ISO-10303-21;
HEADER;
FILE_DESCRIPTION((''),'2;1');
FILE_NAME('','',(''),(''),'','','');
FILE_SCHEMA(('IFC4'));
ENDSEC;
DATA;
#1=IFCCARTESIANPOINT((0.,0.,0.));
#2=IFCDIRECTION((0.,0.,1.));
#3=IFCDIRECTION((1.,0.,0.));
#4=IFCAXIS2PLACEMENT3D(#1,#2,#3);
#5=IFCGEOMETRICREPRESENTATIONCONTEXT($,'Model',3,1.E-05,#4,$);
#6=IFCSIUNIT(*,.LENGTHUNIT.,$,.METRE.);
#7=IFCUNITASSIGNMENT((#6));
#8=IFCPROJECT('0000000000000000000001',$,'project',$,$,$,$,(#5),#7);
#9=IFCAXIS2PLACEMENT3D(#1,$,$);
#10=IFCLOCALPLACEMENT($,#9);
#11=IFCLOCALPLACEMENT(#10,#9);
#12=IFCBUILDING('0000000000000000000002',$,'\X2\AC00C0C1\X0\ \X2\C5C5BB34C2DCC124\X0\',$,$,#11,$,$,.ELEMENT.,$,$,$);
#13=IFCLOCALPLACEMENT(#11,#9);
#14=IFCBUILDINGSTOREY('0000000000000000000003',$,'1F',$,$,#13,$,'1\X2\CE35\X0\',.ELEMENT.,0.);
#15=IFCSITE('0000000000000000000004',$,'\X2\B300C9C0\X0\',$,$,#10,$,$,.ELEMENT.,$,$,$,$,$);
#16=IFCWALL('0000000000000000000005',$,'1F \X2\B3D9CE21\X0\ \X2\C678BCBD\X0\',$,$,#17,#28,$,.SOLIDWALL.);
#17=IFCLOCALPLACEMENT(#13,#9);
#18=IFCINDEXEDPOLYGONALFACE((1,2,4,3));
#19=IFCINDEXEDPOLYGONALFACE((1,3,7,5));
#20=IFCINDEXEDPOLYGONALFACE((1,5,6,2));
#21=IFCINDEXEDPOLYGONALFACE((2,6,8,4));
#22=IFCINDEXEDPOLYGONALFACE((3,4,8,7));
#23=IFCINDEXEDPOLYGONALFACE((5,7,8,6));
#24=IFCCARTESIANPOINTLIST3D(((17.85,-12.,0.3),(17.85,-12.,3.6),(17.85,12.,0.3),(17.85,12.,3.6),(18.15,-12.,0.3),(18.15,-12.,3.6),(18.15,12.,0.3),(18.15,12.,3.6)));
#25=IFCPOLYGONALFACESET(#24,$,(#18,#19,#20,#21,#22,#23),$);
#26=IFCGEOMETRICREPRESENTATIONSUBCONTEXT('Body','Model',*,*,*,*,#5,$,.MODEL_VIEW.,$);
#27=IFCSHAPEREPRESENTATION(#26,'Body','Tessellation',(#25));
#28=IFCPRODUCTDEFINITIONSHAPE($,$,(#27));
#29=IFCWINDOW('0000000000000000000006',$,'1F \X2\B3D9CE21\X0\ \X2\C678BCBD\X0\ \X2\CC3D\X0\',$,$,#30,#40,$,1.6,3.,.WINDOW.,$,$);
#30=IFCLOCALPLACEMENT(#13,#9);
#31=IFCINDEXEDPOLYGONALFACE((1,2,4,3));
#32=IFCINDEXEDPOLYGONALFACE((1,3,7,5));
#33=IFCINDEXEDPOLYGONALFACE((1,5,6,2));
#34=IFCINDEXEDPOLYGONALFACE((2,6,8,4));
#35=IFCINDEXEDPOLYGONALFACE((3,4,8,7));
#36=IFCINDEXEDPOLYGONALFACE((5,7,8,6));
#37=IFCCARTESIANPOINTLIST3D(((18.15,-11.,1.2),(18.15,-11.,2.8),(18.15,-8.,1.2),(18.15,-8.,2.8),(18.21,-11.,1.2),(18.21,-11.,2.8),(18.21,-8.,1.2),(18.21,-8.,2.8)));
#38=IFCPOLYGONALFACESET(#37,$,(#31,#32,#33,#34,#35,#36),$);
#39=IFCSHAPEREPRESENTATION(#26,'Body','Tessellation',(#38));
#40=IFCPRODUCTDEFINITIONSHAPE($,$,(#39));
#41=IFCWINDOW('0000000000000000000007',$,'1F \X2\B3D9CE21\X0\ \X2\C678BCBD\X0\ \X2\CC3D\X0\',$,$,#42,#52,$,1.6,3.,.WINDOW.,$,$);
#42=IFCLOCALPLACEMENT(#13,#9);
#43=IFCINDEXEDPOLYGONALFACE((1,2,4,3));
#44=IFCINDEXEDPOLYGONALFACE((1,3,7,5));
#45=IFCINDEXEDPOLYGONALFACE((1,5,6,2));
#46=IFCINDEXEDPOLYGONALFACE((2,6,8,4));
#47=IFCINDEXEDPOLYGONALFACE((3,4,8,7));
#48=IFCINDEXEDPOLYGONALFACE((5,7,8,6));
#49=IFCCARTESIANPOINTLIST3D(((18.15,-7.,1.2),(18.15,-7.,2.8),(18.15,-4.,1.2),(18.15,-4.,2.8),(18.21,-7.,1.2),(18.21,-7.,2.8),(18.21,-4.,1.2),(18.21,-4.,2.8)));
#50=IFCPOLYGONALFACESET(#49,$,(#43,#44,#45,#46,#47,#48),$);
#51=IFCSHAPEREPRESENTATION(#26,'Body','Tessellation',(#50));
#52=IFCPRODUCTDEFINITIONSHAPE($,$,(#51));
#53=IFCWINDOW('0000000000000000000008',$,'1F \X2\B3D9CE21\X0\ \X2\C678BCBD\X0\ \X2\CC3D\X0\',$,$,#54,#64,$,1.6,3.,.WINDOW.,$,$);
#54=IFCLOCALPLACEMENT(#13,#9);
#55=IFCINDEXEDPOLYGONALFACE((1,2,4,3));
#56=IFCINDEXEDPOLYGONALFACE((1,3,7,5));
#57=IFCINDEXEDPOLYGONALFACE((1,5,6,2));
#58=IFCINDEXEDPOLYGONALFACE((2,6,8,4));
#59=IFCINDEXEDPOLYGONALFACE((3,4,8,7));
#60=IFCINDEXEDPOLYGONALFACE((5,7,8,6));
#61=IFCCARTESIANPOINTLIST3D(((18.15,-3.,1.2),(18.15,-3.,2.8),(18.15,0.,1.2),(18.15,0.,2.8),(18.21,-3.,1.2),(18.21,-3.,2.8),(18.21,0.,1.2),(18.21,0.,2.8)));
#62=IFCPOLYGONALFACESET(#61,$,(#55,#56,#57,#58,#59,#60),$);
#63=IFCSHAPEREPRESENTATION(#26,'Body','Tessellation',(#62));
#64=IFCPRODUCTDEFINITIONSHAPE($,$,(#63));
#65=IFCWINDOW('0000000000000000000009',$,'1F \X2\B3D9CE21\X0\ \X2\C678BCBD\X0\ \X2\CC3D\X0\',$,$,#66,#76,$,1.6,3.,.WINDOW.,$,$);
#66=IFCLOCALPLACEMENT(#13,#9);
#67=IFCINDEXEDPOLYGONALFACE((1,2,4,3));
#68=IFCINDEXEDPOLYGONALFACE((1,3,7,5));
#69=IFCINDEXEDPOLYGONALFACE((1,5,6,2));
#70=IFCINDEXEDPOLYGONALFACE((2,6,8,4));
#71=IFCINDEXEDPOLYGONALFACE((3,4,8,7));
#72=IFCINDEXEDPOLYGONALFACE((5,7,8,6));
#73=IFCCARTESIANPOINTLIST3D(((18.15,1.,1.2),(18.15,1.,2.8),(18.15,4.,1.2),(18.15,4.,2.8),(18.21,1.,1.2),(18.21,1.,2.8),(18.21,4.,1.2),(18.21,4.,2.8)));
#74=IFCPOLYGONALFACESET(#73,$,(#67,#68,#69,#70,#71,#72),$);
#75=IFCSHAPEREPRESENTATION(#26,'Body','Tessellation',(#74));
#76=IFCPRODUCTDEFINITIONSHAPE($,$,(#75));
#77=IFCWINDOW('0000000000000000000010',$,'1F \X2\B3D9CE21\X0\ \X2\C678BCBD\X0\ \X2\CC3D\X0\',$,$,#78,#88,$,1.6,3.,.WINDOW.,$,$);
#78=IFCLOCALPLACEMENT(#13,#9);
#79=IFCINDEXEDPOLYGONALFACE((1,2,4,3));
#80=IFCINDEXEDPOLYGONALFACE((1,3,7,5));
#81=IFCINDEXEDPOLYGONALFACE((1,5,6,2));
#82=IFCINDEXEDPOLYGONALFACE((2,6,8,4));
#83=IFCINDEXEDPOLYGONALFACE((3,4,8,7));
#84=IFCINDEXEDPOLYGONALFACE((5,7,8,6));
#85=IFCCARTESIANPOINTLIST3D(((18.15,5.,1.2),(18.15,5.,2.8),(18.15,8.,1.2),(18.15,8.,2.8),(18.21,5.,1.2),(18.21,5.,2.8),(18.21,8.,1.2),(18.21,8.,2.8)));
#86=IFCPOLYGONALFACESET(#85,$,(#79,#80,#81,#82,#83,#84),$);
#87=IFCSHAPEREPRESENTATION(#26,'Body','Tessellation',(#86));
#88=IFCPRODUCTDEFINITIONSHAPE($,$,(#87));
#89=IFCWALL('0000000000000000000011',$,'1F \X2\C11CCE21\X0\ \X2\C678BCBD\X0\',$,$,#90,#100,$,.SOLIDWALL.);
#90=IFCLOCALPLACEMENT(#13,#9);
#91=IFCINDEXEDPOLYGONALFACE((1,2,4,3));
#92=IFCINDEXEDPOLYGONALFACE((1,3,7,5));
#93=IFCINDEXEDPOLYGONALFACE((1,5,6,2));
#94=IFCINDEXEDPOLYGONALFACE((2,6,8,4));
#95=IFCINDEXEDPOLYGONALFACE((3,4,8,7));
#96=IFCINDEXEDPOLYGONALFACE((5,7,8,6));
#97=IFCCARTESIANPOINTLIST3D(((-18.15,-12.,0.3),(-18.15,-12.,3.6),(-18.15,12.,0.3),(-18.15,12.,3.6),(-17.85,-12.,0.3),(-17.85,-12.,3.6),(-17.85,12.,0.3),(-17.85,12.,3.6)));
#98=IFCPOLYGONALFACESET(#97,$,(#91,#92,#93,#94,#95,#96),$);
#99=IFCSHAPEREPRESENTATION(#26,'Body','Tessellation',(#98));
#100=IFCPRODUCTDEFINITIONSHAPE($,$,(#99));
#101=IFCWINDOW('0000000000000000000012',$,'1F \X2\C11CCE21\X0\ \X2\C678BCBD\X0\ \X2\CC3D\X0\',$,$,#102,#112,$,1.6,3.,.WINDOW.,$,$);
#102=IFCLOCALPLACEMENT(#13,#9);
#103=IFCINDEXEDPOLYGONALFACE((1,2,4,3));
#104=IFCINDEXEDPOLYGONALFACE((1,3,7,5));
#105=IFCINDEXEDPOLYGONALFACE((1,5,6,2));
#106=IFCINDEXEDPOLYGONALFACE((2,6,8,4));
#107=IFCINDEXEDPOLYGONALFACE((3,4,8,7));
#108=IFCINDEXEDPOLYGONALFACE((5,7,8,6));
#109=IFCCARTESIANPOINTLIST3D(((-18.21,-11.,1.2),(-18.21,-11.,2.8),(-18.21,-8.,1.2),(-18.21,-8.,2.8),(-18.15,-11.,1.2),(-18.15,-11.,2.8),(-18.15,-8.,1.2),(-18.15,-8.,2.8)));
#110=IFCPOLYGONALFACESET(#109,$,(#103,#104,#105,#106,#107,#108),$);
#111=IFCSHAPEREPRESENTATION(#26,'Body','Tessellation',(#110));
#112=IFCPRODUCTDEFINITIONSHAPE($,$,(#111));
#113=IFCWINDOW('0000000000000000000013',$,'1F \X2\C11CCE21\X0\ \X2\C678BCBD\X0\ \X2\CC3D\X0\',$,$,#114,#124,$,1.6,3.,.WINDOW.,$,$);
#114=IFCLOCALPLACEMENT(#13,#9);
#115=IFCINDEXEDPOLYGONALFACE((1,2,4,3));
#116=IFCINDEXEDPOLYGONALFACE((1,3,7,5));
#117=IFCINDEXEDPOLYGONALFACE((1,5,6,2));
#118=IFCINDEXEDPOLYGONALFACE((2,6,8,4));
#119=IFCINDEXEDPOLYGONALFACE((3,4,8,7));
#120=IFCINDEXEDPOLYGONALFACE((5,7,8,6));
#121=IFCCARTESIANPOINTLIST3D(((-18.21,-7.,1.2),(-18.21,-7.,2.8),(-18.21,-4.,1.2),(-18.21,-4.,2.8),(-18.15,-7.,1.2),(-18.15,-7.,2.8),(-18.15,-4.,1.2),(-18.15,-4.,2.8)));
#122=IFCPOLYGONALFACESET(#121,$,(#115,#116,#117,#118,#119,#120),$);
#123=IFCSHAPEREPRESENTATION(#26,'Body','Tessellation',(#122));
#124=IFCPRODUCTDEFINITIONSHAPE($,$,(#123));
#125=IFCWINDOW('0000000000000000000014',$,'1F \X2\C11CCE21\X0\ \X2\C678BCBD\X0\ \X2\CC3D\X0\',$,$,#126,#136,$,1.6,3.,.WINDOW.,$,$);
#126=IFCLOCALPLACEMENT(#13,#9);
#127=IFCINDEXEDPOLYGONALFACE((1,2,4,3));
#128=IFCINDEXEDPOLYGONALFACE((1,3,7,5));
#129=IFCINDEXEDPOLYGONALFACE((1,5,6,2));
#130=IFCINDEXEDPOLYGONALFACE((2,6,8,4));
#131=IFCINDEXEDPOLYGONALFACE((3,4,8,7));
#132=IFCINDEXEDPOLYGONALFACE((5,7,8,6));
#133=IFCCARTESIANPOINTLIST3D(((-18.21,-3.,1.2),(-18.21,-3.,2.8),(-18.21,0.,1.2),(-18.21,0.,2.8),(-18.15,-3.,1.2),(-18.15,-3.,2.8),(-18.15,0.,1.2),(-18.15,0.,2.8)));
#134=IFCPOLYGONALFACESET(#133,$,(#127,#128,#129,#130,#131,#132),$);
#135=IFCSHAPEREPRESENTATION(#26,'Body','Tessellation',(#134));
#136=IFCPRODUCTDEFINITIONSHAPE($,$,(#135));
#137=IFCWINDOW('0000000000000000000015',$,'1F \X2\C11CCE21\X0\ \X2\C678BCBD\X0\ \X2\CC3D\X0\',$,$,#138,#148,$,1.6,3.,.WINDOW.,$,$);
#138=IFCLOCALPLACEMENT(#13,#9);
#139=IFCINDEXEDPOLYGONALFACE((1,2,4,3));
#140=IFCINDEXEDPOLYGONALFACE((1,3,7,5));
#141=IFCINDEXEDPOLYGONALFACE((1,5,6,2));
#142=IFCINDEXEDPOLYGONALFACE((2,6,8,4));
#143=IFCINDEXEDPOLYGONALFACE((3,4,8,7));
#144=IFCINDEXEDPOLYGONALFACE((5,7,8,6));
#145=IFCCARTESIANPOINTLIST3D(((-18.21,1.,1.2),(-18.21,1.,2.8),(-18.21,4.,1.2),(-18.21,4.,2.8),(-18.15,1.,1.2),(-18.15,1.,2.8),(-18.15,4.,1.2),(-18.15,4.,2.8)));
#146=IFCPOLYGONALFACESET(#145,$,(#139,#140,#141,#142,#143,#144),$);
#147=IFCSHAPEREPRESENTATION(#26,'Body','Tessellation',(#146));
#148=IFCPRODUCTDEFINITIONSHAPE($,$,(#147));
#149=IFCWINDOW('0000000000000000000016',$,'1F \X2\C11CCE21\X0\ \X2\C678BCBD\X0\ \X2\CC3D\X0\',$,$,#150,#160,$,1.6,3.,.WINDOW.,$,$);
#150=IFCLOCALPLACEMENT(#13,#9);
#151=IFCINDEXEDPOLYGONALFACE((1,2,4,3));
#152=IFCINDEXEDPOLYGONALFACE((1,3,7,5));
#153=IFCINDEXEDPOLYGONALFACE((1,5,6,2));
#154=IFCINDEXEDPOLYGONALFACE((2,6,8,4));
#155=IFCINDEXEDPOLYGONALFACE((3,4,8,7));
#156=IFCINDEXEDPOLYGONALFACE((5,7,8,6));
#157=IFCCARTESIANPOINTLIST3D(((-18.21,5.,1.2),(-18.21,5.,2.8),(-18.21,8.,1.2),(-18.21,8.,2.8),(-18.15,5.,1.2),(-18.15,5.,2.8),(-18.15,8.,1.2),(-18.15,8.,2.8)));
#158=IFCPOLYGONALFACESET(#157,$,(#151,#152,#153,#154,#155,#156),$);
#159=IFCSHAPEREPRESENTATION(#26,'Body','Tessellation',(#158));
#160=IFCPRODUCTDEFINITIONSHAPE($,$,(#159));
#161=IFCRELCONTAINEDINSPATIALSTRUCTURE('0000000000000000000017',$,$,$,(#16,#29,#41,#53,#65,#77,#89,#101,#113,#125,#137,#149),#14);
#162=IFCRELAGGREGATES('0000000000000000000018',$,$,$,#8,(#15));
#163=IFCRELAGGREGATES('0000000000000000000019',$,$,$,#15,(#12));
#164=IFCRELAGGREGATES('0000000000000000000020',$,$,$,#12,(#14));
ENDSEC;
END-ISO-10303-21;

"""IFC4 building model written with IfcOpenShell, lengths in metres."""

from ifc_helpers import new_model, si_unit, frame, origin, origin_with_axes, origin_2d, place, context, subcontext, project, spatial, rectangle, extrude, element, save


model = new_model("IFC4")

# Units and contexts
model_context = context("Model", 3, precision=1e-05, world=origin_with_axes())
body_context = subcontext(model_context, "Body", "Model", "MODEL_VIEW")
ifc_project = project(units=[si_unit("LENGTHUNIT", "METRE")], contexts=[model_context])

# Site, building, storey
site_placement = place(None, origin())
site = spatial("IfcSite", under=ifc_project, at=site_placement, Name="대지", CompositionType="ELEMENT")
building_placement = place(site_placement, origin())
building = spatial("IfcBuilding", under=site, at=building_placement, Name="가상 업무시설", CompositionType="ELEMENT")
storey_placement = place(building_placement, origin())
storey = spatial("IfcBuildingStorey", under=building, at=storey_placement, Name="1F", LongName="1층", CompositionType="ELEMENT", Elevation=0.0)

# Wall
wall_1_placement = place(storey_placement, frame((18.0, 0.0, 0.3)))
element("IfcWall", 1, at=wall_1_placement, inside=storey, Name="1F 동측 외벽", PredefinedType="SOLIDWALL", context=body_context, shape_type="SweptSolid", body=[
    extrude(rectangle(XDim=0.3, YDim=24.0, at=origin_2d()), origin_with_axes(), (0.0, 0.0, 1.0), 3.3),
])

# Windows
for number, where, name in (
    (2, (18.18, -9.5, 1.2), "1F 동측 외벽 창"),
    (3, (18.18, -5.5, 1.2), "1F 동측 외벽 창"),
    (4, (18.18, -1.5, 1.2), "1F 동측 외벽 창"),
    (5, (18.18, 2.5, 1.2), "1F 동측 외벽 창"),
    (6, (18.18, 6.5, 1.2), "1F 동측 외벽 창"),
):
    element("IfcWindow", number, at=place(storey_placement, frame(where)), inside=storey, Name=name, OverallHeight=1.6, OverallWidth=3.0, PredefinedType="WINDOW", context=body_context, shape_type="SweptSolid", body=[
        extrude(rectangle(XDim=0.06, YDim=3.0, at=origin_2d()), origin_with_axes(), (0.0, 0.0, 1.0), 1.6),
    ])

# Wall
wall_2_placement = place(storey_placement, frame((-18.0, 0.0, 0.3)))
element("IfcWall", 7, at=wall_2_placement, inside=storey, Name="1F 서측 외벽", PredefinedType="SOLIDWALL", context=body_context, shape_type="SweptSolid", body=[
    extrude(rectangle(XDim=0.3, YDim=24.0, at=origin_2d()), origin_with_axes(), (0.0, 0.0, 1.0), 3.3),
])

# Windows
for number, where, name in (
    (8, (-18.18, -9.5, 1.2), "1F 서측 외벽 창"),
    (9, (-18.18, -5.5, 1.2), "1F 서측 외벽 창"),
    (10, (-18.18, -1.5, 1.2), "1F 서측 외벽 창"),
    (11, (-18.18, 2.5, 1.2), "1F 서측 외벽 창"),
    (12, (-18.18, 6.5, 1.2), "1F 서측 외벽 창"),
):
    element("IfcWindow", number, at=place(storey_placement, frame(where)), inside=storey, Name=name, OverallHeight=1.6, OverallWidth=3.0, PredefinedType="WINDOW", context=body_context, shape_type="SweptSolid", body=[
        extrude(rectangle(XDim=0.06, YDim=3.0, at=origin_2d()), origin_with_axes(), (0.0, 0.0, 1.0), 1.6),
    ])

save(model, "model.ifc")
